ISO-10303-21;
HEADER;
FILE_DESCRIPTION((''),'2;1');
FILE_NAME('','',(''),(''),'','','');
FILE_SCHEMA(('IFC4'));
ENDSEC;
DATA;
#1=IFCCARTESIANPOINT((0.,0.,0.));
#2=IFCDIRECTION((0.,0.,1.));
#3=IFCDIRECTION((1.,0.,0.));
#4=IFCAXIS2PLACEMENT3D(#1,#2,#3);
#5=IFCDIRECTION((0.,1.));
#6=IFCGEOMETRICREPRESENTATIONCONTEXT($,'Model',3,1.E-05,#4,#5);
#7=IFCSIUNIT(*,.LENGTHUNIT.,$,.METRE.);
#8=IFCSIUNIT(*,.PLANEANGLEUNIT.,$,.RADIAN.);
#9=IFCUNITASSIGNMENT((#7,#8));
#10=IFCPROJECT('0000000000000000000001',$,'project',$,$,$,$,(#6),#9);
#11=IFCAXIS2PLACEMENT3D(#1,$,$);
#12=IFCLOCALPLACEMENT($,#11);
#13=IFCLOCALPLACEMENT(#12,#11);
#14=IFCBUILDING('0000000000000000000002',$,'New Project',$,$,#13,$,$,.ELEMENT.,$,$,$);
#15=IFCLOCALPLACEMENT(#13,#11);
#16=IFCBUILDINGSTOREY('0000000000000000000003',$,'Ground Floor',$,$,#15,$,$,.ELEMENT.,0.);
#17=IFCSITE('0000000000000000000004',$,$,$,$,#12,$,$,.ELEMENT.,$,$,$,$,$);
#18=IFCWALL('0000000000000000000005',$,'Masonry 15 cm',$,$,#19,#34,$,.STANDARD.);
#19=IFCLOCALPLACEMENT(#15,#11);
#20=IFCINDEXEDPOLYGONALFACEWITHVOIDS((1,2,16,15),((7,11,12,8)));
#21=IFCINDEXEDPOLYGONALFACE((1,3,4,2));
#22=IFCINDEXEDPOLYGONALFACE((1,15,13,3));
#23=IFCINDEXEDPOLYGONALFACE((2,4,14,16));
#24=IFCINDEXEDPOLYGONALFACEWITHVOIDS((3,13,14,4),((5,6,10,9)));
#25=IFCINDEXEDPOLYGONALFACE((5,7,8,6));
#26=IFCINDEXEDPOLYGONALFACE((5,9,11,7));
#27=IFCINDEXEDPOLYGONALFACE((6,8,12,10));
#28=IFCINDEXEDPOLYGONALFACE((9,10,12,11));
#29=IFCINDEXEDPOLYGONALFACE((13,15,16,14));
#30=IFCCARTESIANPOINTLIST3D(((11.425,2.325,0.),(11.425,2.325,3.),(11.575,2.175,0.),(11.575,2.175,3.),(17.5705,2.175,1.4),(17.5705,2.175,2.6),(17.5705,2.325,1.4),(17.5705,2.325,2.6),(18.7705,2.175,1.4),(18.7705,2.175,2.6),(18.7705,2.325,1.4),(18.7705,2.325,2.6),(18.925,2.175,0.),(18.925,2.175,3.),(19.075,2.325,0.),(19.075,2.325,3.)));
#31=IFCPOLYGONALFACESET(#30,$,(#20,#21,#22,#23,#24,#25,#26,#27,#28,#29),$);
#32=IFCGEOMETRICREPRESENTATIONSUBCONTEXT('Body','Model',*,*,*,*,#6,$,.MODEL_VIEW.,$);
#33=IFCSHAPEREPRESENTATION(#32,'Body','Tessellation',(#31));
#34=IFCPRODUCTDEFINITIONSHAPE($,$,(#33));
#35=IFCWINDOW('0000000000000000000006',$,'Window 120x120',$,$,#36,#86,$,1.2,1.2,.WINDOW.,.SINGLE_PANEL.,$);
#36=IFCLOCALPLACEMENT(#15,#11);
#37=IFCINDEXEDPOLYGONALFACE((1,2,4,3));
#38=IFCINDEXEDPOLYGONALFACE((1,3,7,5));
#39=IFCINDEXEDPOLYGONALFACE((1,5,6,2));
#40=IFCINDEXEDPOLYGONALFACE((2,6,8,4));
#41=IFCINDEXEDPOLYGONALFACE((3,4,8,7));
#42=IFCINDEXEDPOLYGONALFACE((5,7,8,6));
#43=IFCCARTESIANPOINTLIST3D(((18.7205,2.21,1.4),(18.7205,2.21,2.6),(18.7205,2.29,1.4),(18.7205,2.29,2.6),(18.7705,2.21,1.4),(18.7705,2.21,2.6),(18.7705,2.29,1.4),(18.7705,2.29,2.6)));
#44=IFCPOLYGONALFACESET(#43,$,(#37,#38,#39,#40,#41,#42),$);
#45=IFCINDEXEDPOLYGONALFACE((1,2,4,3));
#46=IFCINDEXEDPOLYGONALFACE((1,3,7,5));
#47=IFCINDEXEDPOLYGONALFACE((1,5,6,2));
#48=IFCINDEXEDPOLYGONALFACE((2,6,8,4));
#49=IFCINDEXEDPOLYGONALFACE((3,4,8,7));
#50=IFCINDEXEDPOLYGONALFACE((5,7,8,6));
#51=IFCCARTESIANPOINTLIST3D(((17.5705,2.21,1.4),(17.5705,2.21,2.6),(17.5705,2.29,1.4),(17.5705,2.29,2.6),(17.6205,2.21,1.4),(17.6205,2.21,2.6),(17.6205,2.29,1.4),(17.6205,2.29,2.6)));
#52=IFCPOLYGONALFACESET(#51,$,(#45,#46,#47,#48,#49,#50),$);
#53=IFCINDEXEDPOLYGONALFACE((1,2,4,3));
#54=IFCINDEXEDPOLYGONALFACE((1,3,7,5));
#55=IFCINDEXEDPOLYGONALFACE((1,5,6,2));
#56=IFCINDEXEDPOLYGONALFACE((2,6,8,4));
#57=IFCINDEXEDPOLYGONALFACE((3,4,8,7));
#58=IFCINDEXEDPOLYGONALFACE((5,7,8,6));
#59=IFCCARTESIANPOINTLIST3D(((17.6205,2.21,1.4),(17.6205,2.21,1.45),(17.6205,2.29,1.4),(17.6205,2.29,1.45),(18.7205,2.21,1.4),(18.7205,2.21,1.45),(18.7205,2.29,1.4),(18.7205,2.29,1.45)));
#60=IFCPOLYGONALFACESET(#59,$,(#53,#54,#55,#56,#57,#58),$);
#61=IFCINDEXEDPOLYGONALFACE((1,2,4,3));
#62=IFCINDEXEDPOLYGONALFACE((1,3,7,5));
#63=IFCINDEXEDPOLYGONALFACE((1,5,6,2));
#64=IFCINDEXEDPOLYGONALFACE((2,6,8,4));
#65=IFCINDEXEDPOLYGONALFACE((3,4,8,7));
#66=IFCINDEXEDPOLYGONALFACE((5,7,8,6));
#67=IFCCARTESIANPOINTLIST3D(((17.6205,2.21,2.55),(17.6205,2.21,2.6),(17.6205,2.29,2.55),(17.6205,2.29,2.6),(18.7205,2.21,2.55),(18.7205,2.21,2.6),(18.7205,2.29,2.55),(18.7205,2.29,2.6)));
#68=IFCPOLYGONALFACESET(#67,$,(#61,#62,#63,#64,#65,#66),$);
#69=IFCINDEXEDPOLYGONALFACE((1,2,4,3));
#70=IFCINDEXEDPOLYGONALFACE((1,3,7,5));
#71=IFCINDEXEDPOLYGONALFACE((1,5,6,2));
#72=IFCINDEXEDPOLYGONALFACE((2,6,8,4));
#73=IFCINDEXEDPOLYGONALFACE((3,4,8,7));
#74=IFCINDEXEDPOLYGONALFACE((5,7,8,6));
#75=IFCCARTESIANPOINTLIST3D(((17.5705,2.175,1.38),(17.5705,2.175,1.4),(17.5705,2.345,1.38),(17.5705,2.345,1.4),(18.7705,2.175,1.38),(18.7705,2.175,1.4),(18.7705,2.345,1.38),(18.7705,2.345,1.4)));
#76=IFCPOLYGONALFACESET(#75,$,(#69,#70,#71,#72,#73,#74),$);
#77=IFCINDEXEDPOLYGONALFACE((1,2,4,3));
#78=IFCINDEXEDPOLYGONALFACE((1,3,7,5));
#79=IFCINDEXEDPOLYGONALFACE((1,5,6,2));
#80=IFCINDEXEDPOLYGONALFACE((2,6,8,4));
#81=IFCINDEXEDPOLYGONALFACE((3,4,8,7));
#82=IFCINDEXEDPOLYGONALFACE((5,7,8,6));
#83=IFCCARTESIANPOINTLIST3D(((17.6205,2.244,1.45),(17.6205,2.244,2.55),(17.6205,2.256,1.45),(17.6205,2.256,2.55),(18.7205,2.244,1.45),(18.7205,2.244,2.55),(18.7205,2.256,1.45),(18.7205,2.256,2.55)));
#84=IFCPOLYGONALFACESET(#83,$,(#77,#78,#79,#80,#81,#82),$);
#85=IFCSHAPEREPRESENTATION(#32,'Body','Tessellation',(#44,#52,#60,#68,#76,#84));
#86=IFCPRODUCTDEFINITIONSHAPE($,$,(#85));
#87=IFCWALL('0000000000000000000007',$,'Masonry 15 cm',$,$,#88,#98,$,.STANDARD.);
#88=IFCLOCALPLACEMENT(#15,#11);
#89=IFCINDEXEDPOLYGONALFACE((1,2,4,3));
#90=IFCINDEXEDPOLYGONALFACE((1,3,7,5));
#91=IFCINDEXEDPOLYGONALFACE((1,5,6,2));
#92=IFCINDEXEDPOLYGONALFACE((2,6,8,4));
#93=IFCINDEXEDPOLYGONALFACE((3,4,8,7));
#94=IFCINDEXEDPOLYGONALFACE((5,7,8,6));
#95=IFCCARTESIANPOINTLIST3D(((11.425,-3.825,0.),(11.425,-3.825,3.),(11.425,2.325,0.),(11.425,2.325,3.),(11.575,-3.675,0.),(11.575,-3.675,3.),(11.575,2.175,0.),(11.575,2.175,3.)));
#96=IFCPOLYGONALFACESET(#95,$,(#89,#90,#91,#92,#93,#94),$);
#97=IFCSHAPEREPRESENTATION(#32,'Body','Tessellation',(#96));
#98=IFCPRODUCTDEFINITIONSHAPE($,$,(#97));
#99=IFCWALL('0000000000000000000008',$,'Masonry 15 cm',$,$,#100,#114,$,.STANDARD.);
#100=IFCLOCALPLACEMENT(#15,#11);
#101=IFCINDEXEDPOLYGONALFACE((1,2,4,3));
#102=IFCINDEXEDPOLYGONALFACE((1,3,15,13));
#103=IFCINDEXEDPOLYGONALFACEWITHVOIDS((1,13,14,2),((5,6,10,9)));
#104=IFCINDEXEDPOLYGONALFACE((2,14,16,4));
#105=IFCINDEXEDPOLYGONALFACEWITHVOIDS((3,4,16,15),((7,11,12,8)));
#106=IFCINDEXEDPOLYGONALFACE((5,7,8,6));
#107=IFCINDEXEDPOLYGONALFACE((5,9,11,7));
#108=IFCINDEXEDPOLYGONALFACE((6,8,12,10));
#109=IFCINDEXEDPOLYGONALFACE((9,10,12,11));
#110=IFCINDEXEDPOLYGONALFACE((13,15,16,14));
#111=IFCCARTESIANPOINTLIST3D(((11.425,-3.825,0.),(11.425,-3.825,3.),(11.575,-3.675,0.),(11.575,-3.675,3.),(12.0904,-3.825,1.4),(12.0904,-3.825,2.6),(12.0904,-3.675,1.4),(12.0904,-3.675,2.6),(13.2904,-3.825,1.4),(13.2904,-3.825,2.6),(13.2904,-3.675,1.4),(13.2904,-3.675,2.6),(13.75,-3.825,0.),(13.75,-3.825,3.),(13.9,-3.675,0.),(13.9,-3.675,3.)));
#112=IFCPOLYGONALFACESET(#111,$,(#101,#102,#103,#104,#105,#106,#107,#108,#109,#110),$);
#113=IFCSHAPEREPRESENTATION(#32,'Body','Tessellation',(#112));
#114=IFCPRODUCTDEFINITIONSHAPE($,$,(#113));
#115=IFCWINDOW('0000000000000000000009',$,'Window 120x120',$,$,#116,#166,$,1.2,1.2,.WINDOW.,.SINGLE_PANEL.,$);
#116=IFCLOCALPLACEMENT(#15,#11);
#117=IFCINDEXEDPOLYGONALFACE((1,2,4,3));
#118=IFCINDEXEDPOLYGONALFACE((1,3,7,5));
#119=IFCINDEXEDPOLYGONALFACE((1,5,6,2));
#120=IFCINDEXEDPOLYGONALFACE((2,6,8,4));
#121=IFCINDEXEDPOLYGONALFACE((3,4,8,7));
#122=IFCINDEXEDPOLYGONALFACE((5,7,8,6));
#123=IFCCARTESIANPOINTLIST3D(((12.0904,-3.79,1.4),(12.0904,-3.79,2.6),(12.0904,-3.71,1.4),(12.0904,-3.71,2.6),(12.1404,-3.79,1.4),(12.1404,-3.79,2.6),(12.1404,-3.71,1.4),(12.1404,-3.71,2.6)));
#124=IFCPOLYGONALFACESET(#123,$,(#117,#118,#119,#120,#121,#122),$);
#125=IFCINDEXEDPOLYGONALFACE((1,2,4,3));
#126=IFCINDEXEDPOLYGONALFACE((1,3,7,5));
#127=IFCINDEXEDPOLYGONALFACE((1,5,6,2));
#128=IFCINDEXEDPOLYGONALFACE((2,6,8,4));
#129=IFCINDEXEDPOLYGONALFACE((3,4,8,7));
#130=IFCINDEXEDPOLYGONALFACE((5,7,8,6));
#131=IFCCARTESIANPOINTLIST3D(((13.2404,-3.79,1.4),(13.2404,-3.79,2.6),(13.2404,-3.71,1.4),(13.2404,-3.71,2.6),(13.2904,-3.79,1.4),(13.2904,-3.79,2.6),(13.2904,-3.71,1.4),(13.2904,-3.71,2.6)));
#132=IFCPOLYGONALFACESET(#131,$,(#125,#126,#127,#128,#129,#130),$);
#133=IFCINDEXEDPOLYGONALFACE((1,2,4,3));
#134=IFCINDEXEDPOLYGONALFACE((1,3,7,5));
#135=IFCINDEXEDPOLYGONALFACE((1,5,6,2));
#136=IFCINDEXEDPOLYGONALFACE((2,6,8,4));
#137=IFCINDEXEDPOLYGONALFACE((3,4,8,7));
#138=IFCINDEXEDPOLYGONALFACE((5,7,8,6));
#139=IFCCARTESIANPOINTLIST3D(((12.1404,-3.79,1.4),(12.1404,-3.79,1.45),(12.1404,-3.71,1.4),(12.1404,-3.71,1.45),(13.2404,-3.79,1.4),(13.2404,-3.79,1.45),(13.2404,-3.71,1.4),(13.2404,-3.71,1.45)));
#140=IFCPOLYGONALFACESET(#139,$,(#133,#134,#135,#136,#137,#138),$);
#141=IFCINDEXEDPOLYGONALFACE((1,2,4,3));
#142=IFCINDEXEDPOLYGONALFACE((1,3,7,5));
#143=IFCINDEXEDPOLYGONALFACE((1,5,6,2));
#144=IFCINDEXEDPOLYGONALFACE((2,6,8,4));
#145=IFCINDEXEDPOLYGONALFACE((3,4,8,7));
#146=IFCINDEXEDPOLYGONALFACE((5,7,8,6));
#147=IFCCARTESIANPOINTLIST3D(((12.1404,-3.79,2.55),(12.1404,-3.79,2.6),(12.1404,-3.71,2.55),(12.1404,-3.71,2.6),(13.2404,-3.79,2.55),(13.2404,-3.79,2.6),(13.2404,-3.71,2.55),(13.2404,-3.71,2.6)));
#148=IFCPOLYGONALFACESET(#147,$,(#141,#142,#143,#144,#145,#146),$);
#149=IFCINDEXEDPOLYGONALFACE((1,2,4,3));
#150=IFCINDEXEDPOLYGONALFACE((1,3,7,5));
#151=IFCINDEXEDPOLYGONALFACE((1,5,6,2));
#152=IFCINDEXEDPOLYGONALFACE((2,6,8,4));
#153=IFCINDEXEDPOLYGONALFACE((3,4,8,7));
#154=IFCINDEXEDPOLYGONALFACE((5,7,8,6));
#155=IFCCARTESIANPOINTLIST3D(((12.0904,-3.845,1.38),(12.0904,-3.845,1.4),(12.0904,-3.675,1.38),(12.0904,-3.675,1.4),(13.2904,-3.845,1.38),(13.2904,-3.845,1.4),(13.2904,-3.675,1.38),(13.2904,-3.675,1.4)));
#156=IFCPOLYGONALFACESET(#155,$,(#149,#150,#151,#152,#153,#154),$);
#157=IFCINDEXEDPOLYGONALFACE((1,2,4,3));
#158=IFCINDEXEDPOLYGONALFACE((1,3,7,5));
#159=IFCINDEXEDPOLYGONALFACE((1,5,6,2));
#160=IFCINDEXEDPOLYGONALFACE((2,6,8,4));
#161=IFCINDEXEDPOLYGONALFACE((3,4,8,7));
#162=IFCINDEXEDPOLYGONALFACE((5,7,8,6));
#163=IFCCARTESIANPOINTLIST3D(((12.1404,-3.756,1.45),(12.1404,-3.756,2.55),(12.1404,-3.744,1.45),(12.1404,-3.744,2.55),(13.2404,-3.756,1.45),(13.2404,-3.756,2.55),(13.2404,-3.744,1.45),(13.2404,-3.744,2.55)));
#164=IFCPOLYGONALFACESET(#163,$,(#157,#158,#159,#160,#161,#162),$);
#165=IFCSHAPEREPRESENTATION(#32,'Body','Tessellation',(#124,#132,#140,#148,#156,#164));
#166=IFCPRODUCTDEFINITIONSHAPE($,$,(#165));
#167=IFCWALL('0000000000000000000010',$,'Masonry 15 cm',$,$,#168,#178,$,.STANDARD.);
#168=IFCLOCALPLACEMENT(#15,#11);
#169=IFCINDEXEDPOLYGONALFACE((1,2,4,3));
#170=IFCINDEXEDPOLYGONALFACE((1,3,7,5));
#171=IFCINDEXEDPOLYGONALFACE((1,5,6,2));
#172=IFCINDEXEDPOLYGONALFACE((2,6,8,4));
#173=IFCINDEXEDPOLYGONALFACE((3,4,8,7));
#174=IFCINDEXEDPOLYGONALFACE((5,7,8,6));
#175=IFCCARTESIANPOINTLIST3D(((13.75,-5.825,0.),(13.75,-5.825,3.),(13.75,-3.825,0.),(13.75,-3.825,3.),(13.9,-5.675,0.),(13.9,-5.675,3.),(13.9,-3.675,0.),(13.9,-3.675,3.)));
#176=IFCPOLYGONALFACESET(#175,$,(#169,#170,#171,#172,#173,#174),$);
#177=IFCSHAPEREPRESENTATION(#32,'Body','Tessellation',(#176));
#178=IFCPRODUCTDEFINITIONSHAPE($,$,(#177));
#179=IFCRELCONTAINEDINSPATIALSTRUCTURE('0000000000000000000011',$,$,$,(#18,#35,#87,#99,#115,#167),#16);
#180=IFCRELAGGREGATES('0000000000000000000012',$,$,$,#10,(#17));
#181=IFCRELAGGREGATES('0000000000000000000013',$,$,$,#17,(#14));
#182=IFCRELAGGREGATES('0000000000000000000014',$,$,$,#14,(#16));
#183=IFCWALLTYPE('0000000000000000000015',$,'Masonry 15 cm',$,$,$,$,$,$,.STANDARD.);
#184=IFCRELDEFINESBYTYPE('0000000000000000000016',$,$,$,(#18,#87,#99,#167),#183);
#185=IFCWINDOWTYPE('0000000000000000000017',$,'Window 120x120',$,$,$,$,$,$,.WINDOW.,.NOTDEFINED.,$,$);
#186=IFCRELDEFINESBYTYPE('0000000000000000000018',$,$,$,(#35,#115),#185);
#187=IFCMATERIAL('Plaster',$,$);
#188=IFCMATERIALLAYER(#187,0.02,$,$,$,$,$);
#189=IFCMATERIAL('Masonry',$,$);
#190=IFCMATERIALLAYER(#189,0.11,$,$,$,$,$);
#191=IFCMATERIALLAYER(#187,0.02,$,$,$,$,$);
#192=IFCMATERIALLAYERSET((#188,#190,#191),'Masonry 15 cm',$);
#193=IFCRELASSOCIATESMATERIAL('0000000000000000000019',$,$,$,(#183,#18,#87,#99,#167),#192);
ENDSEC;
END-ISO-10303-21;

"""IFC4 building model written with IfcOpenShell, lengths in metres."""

from ifc_helpers import new_model, si_unit, direction, frame, frame_2d, origin, origin_with_axes, place, context, subcontext, project, spatial, polyline, rectangle, outline, extrude, material, layer, layer_set, layer_usage, type_object, element, fill, save


model = new_model("IFC4")

# Units and contexts
model_context = context("Model", 3, precision=1e-05, world=origin_with_axes(), true_north=direction((0.0, 1.0)))
body_context = subcontext(model_context, "Body", "Model", "MODEL_VIEW")
ifc_project = project(units=[si_unit("LENGTHUNIT", "METRE"), si_unit("PLANEANGLEUNIT", "RADIAN")], contexts=[model_context])

# Site, building, storey
site_placement = place(None, origin())
site = spatial("IfcSite", under=ifc_project, at=site_placement, CompositionType="ELEMENT")
building_placement = place(site_placement, origin())
building = spatial("IfcBuilding", under=site, at=building_placement, Name="New Project", CompositionType="ELEMENT")
storey_placement = place(building_placement, origin())
storey = spatial("IfcBuildingStorey", under=building, at=storey_placement, Name="Ground Floor", CompositionType="ELEMENT", Elevation=0.0)

# Wall, opening, window
ifc_material_1 = material(Name="Plaster")
ifc_layer_1 = layer(ifc_material_1, 0.02)
ifc_material_2 = material(Name="Masonry")
ifc_layer_2 = layer(ifc_material_2, 0.11)
ifc_layer_3 = layer(ifc_material_1, 0.02)
ifc_layer_set_1 = layer_set([ifc_layer_1, ifc_layer_2, ifc_layer_3], Name="Masonry 15 cm")
ifc_layer_usage_1 = layer_usage(ifc_layer_set_1, "AXIS2", "NEGATIVE", 0.075)
wall_type_1 = type_object("IfcWallType", Name="Masonry 15 cm", PredefinedType="STANDARD", material=ifc_layer_set_1)
wall_1_placement = place(storey_placement, frame((11.5, 2.25, 0.0), z_axis=(0.0, 0.0, 1.0), x_axis=(1.0, 0.0, 0.0)))
wall_1 = element("IfcWall", 1, at=wall_1_placement, inside=storey, type_object=wall_type_1, material=ifc_layer_usage_1, Name="Masonry 15 cm", PredefinedType="STANDARD", context=body_context, shape_type="SweptSolid", body=[
    extrude(outline(polyline([(0.075, -0.075), (7.425, -0.075), (7.575, 0.075), (-0.075, 0.075), (0.075, -0.075)])), origin(), (0.0, 0.0, 1.0), 3.0),
])
opening_1_placement = place(wall_1_placement, frame((6.0705, 0.0, 1.4)))
opening_1 = element("IfcOpeningElement", 2, at=opening_1_placement, cuts=wall_1, PredefinedType="OPENING", context=body_context, shape_type="SweptSolid", body=[
    extrude(rectangle(XDim=1.2, YDim=0.25, at=frame_2d((0.6, 0.0))), origin(), (0.0, 0.0, 1.0), 1.2),
])
window_type_1 = type_object("IfcWindowType", Name="Window 120x120", PartitioningType="NOTDEFINED", PredefinedType="WINDOW")
window_1_placement = place(opening_1_placement, origin())
window_1 = element("IfcWindow", 3, at=window_1_placement, inside=storey, type_object=window_type_1, Name="Window 120x120", OverallHeight=1.2, OverallWidth=1.2, PartitioningType="SINGLE_PANEL", PredefinedType="WINDOW", context=body_context, shape_type="SweptSolid", body=[
    extrude(outline(polyline([(1.2, 0.04), (1.15, 0.04), (1.15, -0.04), (1.2, -0.04), (1.2, 0.04)])), origin(), (0.0, 0.0, 1.0), 1.2),
    extrude(outline(polyline([(0.05, 0.04), (0.0, 0.04), (0.0, -0.04), (0.05, -0.04), (0.05, 0.04)])), origin(), (0.0, 0.0, 1.0), 1.2),
    extrude(outline(polyline([(1.15, 0.04), (0.05, 0.04), (0.05, -0.04), (1.15, -0.04), (1.15, 0.04)])), origin(), (0.0, 0.0, 1.0), 0.05),
    extrude(outline(polyline([(1.15, 0.04), (0.05, 0.04), (0.05, -0.04), (1.15, -0.04), (1.15, 0.04)])), frame((0.0, 0.0, 1.15)), (0.0, 0.0, 1.0), 0.05),
    extrude(outline(polyline([(1.2, 0.095), (0.0, 0.095), (0.0, -0.075), (1.2, -0.075), (1.2, 0.095)])), frame((0.0, 0.0, -0.02)), (0.0, 0.0, 1.0), 0.02),
    extrude(outline(polyline([(1.15, 0.006), (0.05, 0.006), (0.05, -0.006), (1.15, -0.006), (1.15, 0.006)])), frame((0.0, 0.0, 0.05)), (0.0, 0.0, 1.0), 1.1),
])
fill(opening_1, window_1)

# Wall
wall_2_placement = place(storey_placement, frame((11.5, -3.75, 0.0), z_axis=(0.0, 0.0, 1.0), x_axis=(0.0, 1.0, 0.0)))
element("IfcWall", 4, at=wall_2_placement, inside=storey, type_object=wall_type_1, material=ifc_layer_usage_1, Name="Masonry 15 cm", PredefinedType="STANDARD", context=body_context, shape_type="SweptSolid", body=[
    extrude(outline(polyline([(0.075, -0.075), (5.925, -0.075), (6.075, 0.075), (-0.075, 0.075), (0.075, -0.075)])), origin(), (0.0, 0.0, 1.0), 3.0),
])

# Wall, opening, window
wall_3_placement = place(storey_placement, frame((13.825, -3.75, 0.0), z_axis=(0.0, 0.0, 1.0), x_axis=(-1.0, 0.0, 0.0)))
wall_3 = element("IfcWall", 5, at=wall_3_placement, inside=storey, type_object=wall_type_1, material=ifc_layer_usage_1, Name="Masonry 15 cm", PredefinedType="STANDARD", context=body_context, shape_type="SweptSolid", body=[
    extrude(outline(polyline([(-0.075, -0.075), (2.25, -0.075), (2.4, 0.075), (0.075, 0.075), (-0.075, -0.075)])), origin(), (0.0, 0.0, 1.0), 3.0),
])
opening_2_placement = place(wall_3_placement, frame((0.5346, 0.0, 1.4)))
opening_2 = element("IfcOpeningElement", 6, at=opening_2_placement, cuts=wall_3, PredefinedType="OPENING", context=body_context, shape_type="SweptSolid", body=[
    extrude(rectangle(XDim=1.2, YDim=0.25, at=frame_2d((0.6, 0.0))), origin(), (0.0, 0.0, 1.0), 1.2),
])
window_2_placement = place(opening_2_placement, origin())
window_2 = element("IfcWindow", 7, at=window_2_placement, inside=storey, type_object=window_type_1, Name="Window 120x120", OverallHeight=1.2, OverallWidth=1.2, PartitioningType="SINGLE_PANEL", PredefinedType="WINDOW", context=body_context, shape_type="SweptSolid", body=[
    extrude(outline(polyline([(1.2, 0.04), (1.15, 0.04), (1.15, -0.04), (1.2, -0.04), (1.2, 0.04)])), origin(), (0.0, 0.0, 1.0), 1.2),
    extrude(outline(polyline([(0.05, 0.04), (0.0, 0.04), (0.0, -0.04), (0.05, -0.04), (0.05, 0.04)])), origin(), (0.0, 0.0, 1.0), 1.2),
    extrude(outline(polyline([(1.15, 0.04), (0.05, 0.04), (0.05, -0.04), (1.15, -0.04), (1.15, 0.04)])), origin(), (0.0, 0.0, 1.0), 0.05),
    extrude(outline(polyline([(1.15, 0.04), (0.05, 0.04), (0.05, -0.04), (1.15, -0.04), (1.15, 0.04)])), frame((0.0, 0.0, 1.15)), (0.0, 0.0, 1.0), 0.05),
    extrude(outline(polyline([(1.2, 0.095), (0.0, 0.095), (0.0, -0.075), (1.2, -0.075), (1.2, 0.095)])), frame((0.0, 0.0, -0.02)), (0.0, 0.0, 1.0), 0.02),
    extrude(outline(polyline([(1.15, 0.006), (0.05, 0.006), (0.05, -0.006), (1.15, -0.006), (1.15, 0.006)])), frame((0.0, 0.0, 0.05)), (0.0, 0.0, 1.0), 1.1),
])
fill(opening_2, window_2)

# Wall
wall_4_placement = place(storey_placement, frame((13.825, -5.75, 0.0), z_axis=(0.0, 0.0, 1.0), x_axis=(0.0, 1.0, 0.0)))
element("IfcWall", 8, at=wall_4_placement, inside=storey, type_object=wall_type_1, material=ifc_layer_usage_1, Name="Masonry 15 cm", PredefinedType="STANDARD", context=body_context, shape_type="SweptSolid", body=[
    extrude(outline(polyline([(0.075, -0.075), (2.075, -0.075), (1.925, 0.075), (-0.075, 0.075), (0.075, -0.075)])), origin(), (0.0, 0.0, 1.0), 3.0),
])

save(model, "model.ifc")
